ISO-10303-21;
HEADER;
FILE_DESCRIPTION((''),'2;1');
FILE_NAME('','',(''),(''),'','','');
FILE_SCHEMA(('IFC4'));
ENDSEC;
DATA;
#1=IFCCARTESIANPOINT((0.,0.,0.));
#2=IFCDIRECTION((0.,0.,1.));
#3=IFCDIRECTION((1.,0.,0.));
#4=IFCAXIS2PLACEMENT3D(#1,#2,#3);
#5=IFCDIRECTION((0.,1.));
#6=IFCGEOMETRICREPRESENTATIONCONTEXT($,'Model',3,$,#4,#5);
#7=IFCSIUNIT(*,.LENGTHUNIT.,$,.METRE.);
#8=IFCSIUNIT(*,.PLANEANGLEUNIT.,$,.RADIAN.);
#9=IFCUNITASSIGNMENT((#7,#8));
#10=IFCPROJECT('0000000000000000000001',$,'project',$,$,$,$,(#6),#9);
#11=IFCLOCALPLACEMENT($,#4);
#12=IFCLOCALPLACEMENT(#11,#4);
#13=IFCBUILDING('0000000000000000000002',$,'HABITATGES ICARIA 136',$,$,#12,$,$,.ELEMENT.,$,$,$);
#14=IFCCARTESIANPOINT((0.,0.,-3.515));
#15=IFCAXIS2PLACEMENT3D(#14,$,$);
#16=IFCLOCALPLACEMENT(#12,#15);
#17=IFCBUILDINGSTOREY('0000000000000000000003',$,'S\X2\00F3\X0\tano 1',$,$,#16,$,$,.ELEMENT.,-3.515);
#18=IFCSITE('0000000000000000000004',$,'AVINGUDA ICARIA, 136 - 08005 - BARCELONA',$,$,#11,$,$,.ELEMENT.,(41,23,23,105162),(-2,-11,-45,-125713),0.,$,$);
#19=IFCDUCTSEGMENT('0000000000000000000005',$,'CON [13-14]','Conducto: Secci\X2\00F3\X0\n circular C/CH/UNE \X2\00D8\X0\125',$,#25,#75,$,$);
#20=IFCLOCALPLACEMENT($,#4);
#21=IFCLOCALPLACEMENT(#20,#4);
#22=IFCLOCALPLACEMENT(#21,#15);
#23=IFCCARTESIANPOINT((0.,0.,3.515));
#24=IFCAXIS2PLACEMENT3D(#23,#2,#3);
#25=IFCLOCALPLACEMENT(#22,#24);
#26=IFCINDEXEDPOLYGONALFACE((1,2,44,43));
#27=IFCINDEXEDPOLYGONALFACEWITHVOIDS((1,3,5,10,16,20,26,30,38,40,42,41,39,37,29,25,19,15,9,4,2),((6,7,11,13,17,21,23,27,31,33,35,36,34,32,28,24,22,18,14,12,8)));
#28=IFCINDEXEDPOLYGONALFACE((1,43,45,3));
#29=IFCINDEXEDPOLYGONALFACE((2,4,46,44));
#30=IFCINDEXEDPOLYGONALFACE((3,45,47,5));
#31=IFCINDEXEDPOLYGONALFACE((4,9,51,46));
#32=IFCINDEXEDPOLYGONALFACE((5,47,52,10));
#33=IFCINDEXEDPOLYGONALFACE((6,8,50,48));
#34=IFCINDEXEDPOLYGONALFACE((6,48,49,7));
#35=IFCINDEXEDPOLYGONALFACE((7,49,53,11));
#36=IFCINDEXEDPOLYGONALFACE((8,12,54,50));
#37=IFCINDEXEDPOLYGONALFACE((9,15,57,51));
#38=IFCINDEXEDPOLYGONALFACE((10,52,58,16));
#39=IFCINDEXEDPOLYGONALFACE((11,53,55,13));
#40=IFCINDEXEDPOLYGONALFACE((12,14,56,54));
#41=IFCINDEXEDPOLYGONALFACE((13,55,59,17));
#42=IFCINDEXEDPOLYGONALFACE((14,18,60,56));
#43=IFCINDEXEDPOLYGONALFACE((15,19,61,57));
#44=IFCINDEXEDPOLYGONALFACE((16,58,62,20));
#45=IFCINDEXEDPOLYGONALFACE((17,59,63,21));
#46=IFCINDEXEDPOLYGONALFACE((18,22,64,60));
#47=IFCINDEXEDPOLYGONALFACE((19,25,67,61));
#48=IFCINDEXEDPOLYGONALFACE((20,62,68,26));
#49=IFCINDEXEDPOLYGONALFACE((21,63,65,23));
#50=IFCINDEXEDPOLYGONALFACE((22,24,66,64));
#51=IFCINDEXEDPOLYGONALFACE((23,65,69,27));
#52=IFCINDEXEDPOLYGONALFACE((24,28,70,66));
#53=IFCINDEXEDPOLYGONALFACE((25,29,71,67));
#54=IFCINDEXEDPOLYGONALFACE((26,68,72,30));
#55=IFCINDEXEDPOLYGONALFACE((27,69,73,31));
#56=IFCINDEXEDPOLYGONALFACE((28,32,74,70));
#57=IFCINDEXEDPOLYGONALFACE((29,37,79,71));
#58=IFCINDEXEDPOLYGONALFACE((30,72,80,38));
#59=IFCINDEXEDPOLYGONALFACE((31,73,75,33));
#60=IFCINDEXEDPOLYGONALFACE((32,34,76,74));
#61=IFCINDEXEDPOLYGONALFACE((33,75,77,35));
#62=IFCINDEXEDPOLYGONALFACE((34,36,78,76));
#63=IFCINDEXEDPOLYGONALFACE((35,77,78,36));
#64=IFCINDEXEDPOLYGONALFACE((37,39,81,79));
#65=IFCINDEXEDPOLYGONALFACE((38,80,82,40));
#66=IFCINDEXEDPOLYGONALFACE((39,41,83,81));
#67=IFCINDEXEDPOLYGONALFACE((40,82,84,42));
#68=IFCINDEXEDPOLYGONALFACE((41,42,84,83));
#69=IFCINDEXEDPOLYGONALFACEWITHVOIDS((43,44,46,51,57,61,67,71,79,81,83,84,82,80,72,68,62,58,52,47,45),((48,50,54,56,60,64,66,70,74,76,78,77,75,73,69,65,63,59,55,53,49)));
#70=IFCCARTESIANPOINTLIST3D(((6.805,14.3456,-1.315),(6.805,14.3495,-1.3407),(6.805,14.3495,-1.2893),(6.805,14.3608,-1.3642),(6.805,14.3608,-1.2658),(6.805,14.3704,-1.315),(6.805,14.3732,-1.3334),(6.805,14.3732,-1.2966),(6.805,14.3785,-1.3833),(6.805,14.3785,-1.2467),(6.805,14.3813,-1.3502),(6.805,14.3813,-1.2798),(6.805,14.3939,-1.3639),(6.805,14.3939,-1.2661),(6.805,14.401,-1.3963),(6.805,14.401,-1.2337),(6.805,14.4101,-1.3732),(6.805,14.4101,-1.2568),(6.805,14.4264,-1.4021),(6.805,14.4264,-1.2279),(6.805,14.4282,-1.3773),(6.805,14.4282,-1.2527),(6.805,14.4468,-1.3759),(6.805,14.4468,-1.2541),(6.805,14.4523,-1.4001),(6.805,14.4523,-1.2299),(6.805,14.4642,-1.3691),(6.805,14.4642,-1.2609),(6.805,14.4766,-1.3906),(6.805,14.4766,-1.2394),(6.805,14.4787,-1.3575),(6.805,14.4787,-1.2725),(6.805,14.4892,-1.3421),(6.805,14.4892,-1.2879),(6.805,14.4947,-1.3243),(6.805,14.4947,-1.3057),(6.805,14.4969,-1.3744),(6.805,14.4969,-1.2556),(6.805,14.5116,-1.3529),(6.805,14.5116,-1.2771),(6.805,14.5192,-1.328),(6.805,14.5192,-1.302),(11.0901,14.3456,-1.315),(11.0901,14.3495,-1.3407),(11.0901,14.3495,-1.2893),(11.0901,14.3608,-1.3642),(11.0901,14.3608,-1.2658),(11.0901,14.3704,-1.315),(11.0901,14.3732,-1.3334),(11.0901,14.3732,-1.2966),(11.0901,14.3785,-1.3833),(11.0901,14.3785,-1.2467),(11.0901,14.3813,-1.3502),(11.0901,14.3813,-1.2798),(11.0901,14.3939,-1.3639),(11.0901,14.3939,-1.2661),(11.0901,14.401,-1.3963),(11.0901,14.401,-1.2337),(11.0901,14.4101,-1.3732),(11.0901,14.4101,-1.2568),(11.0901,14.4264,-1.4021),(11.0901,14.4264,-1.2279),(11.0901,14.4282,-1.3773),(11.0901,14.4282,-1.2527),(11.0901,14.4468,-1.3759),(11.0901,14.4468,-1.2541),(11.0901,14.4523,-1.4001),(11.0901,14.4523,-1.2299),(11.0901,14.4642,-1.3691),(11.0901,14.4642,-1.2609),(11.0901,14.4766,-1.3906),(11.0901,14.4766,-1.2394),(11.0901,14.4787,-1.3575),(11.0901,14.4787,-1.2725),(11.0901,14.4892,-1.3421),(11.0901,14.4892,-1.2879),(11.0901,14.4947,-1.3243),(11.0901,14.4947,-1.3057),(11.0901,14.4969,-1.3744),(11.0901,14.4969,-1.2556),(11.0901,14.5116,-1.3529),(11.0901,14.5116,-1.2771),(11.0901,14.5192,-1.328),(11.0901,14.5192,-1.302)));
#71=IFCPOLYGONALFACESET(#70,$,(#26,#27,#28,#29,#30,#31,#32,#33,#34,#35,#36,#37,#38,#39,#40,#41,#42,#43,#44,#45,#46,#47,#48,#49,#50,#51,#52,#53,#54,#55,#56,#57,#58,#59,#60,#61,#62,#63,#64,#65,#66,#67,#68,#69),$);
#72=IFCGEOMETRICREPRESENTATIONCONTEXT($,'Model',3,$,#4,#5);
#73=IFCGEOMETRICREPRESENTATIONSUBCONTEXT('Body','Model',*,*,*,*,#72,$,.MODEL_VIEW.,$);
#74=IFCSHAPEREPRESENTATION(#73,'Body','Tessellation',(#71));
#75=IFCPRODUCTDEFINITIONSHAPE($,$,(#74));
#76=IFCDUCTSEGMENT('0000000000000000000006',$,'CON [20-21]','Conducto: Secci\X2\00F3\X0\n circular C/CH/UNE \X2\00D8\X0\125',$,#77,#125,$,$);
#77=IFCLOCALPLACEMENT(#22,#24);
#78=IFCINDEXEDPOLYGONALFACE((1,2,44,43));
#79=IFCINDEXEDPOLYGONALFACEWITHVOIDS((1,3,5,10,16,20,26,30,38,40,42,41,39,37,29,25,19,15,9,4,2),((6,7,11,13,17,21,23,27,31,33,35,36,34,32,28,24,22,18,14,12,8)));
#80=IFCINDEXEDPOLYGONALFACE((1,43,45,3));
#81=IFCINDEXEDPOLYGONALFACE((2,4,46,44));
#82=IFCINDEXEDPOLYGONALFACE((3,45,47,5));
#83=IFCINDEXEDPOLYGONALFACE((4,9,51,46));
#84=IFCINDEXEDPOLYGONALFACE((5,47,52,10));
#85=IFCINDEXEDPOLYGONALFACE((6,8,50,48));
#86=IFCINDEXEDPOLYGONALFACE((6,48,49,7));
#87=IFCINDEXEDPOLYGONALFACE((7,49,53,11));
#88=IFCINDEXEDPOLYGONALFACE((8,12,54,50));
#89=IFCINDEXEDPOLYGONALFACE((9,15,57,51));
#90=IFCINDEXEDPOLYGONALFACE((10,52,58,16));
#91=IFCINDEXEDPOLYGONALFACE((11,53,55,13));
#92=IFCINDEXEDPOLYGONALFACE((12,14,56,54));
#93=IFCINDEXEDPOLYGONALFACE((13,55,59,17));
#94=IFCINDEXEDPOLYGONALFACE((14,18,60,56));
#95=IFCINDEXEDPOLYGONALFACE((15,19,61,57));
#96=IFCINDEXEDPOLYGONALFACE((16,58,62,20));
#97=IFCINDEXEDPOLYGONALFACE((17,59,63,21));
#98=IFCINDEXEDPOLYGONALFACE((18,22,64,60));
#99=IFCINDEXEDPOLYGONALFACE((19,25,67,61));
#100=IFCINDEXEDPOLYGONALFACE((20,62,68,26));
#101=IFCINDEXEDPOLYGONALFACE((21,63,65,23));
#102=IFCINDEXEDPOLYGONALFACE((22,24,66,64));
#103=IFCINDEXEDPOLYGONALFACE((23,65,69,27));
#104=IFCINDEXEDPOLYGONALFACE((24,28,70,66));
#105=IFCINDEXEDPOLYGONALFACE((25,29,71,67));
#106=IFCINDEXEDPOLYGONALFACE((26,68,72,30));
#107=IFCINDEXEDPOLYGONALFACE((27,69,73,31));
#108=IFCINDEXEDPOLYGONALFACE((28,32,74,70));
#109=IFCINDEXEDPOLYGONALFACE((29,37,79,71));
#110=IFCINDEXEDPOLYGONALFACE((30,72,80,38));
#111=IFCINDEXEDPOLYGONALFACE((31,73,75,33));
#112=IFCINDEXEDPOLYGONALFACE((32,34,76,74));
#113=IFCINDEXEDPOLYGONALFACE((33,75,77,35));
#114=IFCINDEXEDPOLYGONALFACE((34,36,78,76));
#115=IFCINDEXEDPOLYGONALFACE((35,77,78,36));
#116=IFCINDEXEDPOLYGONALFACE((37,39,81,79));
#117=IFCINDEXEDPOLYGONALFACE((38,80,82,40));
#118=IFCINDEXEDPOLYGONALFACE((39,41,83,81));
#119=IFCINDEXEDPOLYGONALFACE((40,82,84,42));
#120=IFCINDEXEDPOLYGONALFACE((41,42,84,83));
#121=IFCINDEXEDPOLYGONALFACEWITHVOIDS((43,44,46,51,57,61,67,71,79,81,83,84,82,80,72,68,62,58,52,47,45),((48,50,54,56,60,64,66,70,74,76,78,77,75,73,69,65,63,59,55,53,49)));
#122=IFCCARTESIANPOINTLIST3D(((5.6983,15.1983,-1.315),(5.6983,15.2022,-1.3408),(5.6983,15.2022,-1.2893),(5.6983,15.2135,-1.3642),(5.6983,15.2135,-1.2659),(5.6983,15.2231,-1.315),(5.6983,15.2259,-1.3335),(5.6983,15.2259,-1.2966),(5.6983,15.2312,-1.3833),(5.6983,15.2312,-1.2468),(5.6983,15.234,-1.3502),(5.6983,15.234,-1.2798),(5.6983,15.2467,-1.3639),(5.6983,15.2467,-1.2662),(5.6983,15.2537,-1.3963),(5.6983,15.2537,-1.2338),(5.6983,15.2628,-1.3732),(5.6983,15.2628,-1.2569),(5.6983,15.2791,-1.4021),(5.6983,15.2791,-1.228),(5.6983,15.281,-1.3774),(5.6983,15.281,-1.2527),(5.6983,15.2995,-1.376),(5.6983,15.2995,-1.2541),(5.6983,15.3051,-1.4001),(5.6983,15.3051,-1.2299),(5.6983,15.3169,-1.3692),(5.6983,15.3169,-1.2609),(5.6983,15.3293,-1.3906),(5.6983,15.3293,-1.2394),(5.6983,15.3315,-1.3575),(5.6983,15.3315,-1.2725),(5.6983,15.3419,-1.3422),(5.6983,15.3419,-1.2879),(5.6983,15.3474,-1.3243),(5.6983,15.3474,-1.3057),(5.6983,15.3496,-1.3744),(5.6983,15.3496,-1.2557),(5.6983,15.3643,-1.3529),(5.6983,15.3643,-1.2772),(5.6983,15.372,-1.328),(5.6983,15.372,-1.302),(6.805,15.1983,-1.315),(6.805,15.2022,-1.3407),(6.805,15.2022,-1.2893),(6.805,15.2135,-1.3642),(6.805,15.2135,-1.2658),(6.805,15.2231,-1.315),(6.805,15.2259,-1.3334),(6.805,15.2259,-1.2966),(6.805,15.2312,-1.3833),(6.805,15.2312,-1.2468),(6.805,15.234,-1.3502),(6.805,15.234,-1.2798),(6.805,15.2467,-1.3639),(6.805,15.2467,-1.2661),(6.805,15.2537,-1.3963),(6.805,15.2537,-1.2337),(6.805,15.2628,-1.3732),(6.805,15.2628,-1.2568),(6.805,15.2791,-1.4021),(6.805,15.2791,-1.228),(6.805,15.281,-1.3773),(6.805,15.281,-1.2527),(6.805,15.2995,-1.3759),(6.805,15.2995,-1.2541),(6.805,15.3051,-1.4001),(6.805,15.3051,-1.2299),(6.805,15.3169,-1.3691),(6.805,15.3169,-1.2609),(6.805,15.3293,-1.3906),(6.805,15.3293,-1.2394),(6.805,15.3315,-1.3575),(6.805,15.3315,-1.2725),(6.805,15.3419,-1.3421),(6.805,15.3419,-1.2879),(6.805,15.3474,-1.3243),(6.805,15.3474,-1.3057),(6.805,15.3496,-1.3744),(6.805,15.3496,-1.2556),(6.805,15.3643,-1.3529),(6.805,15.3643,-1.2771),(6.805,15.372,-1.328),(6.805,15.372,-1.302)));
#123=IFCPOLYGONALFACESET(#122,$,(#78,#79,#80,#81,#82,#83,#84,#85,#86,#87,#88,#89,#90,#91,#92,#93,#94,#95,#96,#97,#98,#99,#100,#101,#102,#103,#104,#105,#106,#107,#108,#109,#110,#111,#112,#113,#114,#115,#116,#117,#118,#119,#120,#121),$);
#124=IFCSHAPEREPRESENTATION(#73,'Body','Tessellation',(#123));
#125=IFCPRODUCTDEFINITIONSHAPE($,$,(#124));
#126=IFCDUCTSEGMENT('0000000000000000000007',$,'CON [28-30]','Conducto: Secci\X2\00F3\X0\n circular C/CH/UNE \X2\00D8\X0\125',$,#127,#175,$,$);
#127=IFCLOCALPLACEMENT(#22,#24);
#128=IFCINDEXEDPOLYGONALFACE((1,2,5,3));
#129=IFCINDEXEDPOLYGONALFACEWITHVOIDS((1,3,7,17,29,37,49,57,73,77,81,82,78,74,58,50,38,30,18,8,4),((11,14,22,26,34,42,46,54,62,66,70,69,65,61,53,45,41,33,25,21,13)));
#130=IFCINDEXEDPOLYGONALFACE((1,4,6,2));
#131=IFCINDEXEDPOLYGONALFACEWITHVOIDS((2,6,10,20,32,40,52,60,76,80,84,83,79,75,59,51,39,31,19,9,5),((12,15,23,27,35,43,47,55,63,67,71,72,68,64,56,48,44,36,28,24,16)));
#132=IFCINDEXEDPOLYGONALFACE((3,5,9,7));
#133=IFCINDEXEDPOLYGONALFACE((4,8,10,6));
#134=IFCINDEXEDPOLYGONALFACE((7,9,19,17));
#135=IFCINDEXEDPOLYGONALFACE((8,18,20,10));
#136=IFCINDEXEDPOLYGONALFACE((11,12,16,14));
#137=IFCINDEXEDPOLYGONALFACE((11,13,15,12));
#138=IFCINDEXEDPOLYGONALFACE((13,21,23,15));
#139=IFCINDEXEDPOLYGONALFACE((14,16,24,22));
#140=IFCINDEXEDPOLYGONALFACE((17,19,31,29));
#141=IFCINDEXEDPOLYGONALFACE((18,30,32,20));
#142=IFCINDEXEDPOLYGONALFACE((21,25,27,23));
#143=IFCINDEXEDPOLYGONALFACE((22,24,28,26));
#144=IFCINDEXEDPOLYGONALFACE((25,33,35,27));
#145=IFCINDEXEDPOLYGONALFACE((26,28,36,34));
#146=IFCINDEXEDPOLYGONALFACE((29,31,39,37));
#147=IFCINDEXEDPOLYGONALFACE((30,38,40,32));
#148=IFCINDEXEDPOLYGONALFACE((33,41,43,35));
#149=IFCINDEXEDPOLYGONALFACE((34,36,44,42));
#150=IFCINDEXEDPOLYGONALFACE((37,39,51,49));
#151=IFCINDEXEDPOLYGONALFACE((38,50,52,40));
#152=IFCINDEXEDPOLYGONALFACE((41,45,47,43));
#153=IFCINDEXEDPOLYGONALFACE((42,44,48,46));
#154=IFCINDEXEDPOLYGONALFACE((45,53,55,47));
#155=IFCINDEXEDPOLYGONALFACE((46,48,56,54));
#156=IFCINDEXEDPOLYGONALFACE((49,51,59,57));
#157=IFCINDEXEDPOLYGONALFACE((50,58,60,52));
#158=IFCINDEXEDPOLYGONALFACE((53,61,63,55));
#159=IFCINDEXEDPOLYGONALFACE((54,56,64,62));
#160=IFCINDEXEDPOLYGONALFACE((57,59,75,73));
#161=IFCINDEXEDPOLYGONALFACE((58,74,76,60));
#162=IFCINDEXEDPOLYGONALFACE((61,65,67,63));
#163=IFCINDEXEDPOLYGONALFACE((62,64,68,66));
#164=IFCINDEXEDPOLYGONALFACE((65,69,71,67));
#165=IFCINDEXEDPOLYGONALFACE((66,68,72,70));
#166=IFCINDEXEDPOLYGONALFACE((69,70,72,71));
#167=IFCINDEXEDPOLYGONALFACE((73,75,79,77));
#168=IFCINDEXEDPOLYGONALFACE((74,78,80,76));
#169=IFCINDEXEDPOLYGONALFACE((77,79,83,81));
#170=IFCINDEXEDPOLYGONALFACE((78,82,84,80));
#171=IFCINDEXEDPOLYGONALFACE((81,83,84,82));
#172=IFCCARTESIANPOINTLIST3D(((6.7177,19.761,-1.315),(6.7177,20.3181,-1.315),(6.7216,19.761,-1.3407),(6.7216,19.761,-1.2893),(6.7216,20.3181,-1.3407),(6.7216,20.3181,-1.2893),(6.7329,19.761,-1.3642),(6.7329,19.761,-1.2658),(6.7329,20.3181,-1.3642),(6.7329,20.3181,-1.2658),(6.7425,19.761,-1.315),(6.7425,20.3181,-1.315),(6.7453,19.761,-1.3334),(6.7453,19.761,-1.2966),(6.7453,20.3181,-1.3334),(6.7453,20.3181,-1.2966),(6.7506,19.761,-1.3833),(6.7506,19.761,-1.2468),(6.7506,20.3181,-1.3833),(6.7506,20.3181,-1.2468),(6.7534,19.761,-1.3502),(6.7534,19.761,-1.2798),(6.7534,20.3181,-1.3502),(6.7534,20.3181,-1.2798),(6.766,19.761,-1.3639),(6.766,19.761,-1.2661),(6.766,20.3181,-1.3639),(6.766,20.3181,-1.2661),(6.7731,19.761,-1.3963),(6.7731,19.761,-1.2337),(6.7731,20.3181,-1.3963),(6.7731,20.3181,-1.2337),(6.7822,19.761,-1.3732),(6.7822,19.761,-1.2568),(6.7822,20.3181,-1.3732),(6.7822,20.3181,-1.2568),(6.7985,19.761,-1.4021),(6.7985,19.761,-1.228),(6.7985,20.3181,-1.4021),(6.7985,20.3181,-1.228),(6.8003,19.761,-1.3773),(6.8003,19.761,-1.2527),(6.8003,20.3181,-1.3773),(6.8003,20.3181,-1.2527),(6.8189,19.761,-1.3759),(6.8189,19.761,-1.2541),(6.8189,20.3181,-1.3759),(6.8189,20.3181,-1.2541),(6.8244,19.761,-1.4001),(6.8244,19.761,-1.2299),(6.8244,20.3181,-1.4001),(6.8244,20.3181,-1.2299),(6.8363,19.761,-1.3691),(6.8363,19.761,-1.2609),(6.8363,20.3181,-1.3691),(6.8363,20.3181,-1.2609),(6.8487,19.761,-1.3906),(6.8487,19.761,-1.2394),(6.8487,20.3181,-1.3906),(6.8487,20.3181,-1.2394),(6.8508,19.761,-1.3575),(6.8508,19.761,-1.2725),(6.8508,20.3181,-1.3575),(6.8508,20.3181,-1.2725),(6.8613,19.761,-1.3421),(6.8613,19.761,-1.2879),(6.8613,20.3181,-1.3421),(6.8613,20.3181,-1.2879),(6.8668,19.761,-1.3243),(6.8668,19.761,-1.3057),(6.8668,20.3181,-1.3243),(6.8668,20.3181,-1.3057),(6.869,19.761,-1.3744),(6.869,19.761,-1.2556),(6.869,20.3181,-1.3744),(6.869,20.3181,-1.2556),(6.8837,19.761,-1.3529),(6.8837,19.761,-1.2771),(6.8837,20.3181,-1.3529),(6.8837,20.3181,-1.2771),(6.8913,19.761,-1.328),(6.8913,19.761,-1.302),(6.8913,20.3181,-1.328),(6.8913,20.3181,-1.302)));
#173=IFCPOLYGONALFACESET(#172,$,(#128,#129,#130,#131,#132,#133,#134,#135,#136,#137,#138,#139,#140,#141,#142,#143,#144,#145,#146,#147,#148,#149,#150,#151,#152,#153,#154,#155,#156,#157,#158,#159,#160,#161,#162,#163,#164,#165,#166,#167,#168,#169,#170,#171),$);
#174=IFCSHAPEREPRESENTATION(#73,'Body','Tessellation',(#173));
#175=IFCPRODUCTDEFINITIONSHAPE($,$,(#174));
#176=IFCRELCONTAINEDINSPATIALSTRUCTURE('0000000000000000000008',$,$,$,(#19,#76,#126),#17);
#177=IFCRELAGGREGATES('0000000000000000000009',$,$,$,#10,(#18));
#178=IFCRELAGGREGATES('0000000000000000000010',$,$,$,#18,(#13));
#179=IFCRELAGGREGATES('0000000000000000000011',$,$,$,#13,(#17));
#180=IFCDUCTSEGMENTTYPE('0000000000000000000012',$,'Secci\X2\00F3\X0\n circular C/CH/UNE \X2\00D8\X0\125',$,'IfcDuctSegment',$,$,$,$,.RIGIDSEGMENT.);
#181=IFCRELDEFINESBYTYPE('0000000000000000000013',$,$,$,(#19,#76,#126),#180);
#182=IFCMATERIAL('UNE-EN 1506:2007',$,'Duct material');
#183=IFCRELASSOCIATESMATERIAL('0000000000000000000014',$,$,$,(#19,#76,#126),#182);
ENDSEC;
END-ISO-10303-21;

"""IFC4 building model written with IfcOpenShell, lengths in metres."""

from ifc_helpers import new_model, si_unit, direction, frame, origin_with_axes, origin_2d_with_axis, place, context, subcontext, project, spatial, hollow_circle, extrude, material, type_object, element, save


model = new_model("IFC4")

# Units and contexts
model_context_1 = context("Model", 3, world=origin_with_axes(), true_north=direction((0.0, 1.0)))
model_context_2 = context("Model", 3, world=origin_with_axes(), true_north=direction((0.0, 1.0)))
body_context_1 = subcontext(model_context_2, "Body", "Model", "MODEL_VIEW")
ifc_project = project(units=[si_unit("LENGTHUNIT", "METRE"), si_unit("PLANEANGLEUNIT", "RADIAN")], contexts=[model_context_1])

# Site, building, storey
site_placement = place(None, origin_with_axes())
site = spatial("IfcSite", under=ifc_project, at=site_placement, Name="AVINGUDA ICARIA, 136 - 08005 - BARCELONA", CompositionType="ELEMENT", RefLatitude=(41, 23, 23, 105162), RefLongitude=(-2, -11, -45, -125713), RefElevation=0.0)
building_placement = place(site_placement, origin_with_axes())
building = spatial("IfcBuilding", under=site, at=building_placement, Name="HABITATGES ICARIA 136", CompositionType="ELEMENT")
storey_placement = place(building_placement, frame((0.0, 0.0, -3.515)))
storey = spatial("IfcBuildingStorey", under=building, at=storey_placement, Name="Sótano 1", CompositionType="ELEMENT", Elevation=-3.515)

# Duct segments
ifc_material_1 = material(Name="UNE-EN 1506:2007", Category="Duct material")
duct_segment_type = type_object("IfcDuctSegmentType", Name="Sección circular C/CH/UNE Ø125", ApplicableOccurrence="IfcDuctSegment", PredefinedType="RIGIDSEGMENT")
placement_1 = place(None, origin_with_axes())
placement_2 = place(placement_1, origin_with_axes())
placement_3 = place(placement_2, frame((0.0, 0.0, -3.515)))
duct_segment_1_placement = place(placement_3, frame((0.0, 0.0, 3.515), z_axis=(0.0, 0.0, 1.0), x_axis=(1.0, 0.0, 0.0)))
element("IfcDuctSegment", 1, at=duct_segment_1_placement, inside=storey, type_object=duct_segment_type, material=ifc_material_1, Name="CON [13-14]", Description="Conducto: Sección circular C/CH/UNE Ø125", context=body_context_1, shape_type="SweptSolid", body=[
    extrude(hollow_circle(Radius=0.0873, WallThickness=0.0248, at=origin_2d_with_axis()), frame((11.0901, 14.4329, -1.315), z_axis=(-1.0, 0.0, 0.0), x_axis=(0.0, -1.0, 0.0)), (0.0, 0.0, 1.0), 4.2851),
])
duct_segment_2_placement = place(placement_3, frame((0.0, 0.0, 3.515), z_axis=(0.0, 0.0, 1.0), x_axis=(1.0, 0.0, 0.0)))
element("IfcDuctSegment", 2, at=duct_segment_2_placement, inside=storey, type_object=duct_segment_type, material=ifc_material_1, Name="CON [20-21]", Description="Conducto: Sección circular C/CH/UNE Ø125", context=body_context_1, shape_type="SweptSolid", body=[
    extrude(hollow_circle(Radius=0.0873, WallThickness=0.0248, at=origin_2d_with_axis()), frame((6.805, 15.2856, -1.315), z_axis=(-1.0, 0.0, -0.000017), x_axis=(0.0, -1.0, 0.0)), (0.0, 0.0, 1.0), 1.1067),
])
duct_segment_3_placement = place(placement_3, frame((0.0, 0.0, 3.515), z_axis=(0.0, 0.0, 1.0), x_axis=(1.0, 0.0, 0.0)))
element("IfcDuctSegment", 3, at=duct_segment_3_placement, inside=storey, type_object=duct_segment_type, material=ifc_material_1, Name="CON [28-30]", Description="Conducto: Sección circular C/CH/UNE Ø125", context=body_context_1, shape_type="SweptSolid", body=[
    extrude(hollow_circle(Radius=0.0873, WallThickness=0.0248, at=origin_2d_with_axis()), frame((6.805, 19.761, -1.315), z_axis=(0.0, 1.0, 0.0), x_axis=(-1.0, 0.0, 0.0)), (0.0, 0.0, 1.0), 0.557),
])

save(model, "model.ifc")
